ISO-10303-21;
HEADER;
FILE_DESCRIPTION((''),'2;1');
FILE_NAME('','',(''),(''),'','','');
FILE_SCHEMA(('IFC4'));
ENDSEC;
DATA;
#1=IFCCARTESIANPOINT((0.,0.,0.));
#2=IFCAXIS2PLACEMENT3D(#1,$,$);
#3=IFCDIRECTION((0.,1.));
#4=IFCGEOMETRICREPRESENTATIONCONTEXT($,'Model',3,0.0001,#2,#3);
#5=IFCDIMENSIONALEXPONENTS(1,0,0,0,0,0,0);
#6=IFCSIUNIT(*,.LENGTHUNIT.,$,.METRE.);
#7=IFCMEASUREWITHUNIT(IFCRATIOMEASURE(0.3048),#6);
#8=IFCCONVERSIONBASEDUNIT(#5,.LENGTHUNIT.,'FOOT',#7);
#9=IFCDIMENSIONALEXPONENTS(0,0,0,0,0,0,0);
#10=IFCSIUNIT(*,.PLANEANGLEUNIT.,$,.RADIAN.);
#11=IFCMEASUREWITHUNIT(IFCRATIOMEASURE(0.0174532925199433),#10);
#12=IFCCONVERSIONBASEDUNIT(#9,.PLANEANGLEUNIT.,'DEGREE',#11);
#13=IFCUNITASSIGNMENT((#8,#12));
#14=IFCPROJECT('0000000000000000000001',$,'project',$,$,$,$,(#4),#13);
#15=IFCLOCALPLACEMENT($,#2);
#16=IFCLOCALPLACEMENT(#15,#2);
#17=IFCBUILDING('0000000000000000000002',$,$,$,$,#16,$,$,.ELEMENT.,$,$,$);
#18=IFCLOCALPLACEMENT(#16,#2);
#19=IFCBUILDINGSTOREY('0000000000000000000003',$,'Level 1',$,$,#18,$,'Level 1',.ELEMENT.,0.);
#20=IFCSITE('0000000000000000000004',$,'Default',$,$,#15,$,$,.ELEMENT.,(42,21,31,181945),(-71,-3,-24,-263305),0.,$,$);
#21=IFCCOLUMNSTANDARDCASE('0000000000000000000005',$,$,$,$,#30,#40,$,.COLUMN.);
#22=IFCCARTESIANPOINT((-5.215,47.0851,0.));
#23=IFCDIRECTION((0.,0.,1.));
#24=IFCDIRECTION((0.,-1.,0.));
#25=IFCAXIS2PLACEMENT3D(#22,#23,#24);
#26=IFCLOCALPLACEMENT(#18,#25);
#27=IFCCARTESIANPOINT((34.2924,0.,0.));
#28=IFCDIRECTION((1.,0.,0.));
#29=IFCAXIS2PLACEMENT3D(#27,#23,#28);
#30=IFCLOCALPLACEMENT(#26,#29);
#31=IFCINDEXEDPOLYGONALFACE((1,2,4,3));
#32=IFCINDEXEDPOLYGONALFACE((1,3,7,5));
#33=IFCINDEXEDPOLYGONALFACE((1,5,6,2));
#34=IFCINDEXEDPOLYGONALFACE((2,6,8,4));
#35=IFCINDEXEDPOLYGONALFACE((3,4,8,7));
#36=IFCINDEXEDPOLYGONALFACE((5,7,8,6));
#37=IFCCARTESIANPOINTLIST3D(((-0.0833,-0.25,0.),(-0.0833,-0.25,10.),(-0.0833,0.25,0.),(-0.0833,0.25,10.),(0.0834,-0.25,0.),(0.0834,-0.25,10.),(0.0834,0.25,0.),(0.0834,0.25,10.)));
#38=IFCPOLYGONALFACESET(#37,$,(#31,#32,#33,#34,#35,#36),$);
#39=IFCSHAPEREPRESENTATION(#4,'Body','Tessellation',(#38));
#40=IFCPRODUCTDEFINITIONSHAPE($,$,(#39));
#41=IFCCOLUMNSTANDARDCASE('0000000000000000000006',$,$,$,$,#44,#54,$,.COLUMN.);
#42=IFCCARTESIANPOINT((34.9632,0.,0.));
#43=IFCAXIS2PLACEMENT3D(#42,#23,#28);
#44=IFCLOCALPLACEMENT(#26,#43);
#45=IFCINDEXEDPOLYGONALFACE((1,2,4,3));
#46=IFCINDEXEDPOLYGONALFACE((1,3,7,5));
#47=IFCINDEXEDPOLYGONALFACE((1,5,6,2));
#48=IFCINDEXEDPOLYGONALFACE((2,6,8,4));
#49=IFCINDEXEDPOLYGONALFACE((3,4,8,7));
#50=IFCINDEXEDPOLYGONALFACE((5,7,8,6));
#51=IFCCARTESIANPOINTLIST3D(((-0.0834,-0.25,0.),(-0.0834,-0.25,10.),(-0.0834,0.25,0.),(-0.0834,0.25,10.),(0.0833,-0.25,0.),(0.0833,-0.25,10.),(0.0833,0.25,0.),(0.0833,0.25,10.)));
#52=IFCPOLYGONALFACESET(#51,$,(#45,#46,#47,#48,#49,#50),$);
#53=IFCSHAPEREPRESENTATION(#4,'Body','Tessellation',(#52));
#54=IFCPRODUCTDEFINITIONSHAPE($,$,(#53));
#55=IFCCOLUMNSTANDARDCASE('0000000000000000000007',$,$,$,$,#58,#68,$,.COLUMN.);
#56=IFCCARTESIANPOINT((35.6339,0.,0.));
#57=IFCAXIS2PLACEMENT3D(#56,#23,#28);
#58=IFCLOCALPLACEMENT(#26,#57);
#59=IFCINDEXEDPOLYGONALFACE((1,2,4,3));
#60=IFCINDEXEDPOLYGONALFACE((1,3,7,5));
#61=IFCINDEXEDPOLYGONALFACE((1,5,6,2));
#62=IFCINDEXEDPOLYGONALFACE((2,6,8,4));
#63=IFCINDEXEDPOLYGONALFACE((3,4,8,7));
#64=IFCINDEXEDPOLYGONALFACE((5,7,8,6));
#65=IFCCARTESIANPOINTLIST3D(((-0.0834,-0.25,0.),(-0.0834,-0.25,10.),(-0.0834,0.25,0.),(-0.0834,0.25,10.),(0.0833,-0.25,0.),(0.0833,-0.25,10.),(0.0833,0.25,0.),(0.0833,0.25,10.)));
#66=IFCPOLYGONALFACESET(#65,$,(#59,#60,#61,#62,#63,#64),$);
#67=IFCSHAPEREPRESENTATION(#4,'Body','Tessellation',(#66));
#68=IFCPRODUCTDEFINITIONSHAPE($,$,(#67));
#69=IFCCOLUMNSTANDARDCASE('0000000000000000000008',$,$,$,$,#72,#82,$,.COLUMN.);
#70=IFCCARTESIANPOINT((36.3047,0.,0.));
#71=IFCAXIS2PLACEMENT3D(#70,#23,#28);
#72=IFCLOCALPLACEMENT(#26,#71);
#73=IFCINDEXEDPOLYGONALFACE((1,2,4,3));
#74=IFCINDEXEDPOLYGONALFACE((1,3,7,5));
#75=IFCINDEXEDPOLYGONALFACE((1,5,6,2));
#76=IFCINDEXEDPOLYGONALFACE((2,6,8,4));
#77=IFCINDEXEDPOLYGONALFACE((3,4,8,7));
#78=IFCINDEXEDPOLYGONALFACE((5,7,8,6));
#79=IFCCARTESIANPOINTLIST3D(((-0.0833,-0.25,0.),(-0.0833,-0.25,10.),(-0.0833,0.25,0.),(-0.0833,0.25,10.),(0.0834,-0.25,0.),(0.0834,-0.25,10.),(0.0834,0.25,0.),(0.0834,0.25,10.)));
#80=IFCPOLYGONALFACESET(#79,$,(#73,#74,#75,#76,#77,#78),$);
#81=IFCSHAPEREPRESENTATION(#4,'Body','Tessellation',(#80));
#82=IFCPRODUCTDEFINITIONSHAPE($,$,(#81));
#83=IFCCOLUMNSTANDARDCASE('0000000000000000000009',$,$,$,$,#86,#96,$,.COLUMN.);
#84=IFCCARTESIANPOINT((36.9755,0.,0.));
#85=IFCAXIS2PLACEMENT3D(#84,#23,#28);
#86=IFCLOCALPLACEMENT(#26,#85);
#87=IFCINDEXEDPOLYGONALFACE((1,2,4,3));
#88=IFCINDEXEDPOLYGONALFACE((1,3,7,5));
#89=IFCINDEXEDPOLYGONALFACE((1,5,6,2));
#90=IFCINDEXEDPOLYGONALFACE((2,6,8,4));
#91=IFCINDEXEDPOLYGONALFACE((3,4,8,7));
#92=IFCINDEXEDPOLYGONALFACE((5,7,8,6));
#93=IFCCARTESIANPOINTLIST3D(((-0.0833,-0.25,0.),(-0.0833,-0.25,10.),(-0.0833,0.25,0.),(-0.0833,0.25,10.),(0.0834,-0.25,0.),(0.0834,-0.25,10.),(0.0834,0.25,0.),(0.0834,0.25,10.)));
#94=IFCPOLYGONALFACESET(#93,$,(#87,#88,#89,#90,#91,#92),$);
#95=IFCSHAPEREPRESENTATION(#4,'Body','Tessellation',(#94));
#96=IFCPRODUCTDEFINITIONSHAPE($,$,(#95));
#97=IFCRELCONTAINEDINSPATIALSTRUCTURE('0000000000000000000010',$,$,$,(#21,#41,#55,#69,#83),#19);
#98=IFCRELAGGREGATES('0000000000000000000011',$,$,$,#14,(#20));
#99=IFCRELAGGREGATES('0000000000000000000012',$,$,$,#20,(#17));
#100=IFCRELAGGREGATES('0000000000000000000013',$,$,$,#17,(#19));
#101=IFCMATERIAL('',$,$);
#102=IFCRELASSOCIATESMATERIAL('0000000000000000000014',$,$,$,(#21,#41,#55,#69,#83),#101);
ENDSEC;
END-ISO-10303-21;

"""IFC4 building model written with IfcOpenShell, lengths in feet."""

from ifc_helpers import new_model, entity, si_unit, converted_unit, direction, frame, origin, place, context, project, spatial, rectangle, extrude, material, element, save


model = new_model("IFC4")

# Units and contexts
model_context = context("Model", 3, precision=0.0001, world=origin(), true_north=direction((0.0, 1.0)))
ifc_project = project(units=[converted_unit("LENGTHUNIT", "FOOT", entity("IfcRatioMeasure", 0.3048), si_unit("LENGTHUNIT", "METRE"), dimensions=[1, 0, 0, 0, 0, 0, 0]), converted_unit("PLANEANGLEUNIT", "DEGREE", entity("IfcRatioMeasure", 0.0174532925199433), si_unit("PLANEANGLEUNIT", "RADIAN"), dimensions=[0, 0, 0, 0, 0, 0, 0])], contexts=[model_context])

# Site, building, storey
site_placement = place(None, origin())
site = spatial("IfcSite", under=ifc_project, at=site_placement, Name="Default", CompositionType="ELEMENT", RefLatitude=(42, 21, 31, 181945), RefLongitude=(-71, -3, -24, -263305), RefElevation=0.0)
building_placement = place(site_placement, origin())
building = spatial("IfcBuilding", under=site, at=building_placement, CompositionType="ELEMENT")
storey_placement = place(building_placement, origin())
storey = spatial("IfcBuildingStorey", under=building, at=storey_placement, Name="Level 1", LongName="Level 1", CompositionType="ELEMENT", Elevation=0.0)

# Columns
ifc_material = material(Name="")
placement = place(storey_placement, frame((-5.215, 47.0851, 0.0), z_axis=(0.0, 0.0, 1.0), x_axis=(0.0, -1.0, 0.0)))
for number, where, z_axis, x_axis in (
    (1, (34.2924, 0.0, 0.0), (0.0, 0.0, 1.0), (1.0, 0.0, 0.0)),
    (2, (34.9632, 0.0, 0.0), (0.0, 0.0, 1.0), (1.0, 0.0, 0.0)),
    (3, (35.6339, 0.0, 0.0), (0.0, 0.0, 1.0), (1.0, 0.0, 0.0)),
    (4, (36.3047, 0.0, 0.0), (0.0, 0.0, 1.0), (1.0, 0.0, 0.0)),
    (5, (36.9755, 0.0, 0.0), (0.0, 0.0, 1.0), (1.0, 0.0, 0.0)),
):
    element("IfcColumnStandardCase", number, at=place(placement, frame(where, z_axis=z_axis, x_axis=x_axis)), inside=storey, material=ifc_material, PredefinedType="COLUMN", context=model_context, shape_type="SweptSolid", body=[
        extrude(rectangle(XDim=0.1667, YDim=0.5), origin(), (0.0, 0.0, 1.0), 10.0),
    ])

save(model, "model.ifc")
